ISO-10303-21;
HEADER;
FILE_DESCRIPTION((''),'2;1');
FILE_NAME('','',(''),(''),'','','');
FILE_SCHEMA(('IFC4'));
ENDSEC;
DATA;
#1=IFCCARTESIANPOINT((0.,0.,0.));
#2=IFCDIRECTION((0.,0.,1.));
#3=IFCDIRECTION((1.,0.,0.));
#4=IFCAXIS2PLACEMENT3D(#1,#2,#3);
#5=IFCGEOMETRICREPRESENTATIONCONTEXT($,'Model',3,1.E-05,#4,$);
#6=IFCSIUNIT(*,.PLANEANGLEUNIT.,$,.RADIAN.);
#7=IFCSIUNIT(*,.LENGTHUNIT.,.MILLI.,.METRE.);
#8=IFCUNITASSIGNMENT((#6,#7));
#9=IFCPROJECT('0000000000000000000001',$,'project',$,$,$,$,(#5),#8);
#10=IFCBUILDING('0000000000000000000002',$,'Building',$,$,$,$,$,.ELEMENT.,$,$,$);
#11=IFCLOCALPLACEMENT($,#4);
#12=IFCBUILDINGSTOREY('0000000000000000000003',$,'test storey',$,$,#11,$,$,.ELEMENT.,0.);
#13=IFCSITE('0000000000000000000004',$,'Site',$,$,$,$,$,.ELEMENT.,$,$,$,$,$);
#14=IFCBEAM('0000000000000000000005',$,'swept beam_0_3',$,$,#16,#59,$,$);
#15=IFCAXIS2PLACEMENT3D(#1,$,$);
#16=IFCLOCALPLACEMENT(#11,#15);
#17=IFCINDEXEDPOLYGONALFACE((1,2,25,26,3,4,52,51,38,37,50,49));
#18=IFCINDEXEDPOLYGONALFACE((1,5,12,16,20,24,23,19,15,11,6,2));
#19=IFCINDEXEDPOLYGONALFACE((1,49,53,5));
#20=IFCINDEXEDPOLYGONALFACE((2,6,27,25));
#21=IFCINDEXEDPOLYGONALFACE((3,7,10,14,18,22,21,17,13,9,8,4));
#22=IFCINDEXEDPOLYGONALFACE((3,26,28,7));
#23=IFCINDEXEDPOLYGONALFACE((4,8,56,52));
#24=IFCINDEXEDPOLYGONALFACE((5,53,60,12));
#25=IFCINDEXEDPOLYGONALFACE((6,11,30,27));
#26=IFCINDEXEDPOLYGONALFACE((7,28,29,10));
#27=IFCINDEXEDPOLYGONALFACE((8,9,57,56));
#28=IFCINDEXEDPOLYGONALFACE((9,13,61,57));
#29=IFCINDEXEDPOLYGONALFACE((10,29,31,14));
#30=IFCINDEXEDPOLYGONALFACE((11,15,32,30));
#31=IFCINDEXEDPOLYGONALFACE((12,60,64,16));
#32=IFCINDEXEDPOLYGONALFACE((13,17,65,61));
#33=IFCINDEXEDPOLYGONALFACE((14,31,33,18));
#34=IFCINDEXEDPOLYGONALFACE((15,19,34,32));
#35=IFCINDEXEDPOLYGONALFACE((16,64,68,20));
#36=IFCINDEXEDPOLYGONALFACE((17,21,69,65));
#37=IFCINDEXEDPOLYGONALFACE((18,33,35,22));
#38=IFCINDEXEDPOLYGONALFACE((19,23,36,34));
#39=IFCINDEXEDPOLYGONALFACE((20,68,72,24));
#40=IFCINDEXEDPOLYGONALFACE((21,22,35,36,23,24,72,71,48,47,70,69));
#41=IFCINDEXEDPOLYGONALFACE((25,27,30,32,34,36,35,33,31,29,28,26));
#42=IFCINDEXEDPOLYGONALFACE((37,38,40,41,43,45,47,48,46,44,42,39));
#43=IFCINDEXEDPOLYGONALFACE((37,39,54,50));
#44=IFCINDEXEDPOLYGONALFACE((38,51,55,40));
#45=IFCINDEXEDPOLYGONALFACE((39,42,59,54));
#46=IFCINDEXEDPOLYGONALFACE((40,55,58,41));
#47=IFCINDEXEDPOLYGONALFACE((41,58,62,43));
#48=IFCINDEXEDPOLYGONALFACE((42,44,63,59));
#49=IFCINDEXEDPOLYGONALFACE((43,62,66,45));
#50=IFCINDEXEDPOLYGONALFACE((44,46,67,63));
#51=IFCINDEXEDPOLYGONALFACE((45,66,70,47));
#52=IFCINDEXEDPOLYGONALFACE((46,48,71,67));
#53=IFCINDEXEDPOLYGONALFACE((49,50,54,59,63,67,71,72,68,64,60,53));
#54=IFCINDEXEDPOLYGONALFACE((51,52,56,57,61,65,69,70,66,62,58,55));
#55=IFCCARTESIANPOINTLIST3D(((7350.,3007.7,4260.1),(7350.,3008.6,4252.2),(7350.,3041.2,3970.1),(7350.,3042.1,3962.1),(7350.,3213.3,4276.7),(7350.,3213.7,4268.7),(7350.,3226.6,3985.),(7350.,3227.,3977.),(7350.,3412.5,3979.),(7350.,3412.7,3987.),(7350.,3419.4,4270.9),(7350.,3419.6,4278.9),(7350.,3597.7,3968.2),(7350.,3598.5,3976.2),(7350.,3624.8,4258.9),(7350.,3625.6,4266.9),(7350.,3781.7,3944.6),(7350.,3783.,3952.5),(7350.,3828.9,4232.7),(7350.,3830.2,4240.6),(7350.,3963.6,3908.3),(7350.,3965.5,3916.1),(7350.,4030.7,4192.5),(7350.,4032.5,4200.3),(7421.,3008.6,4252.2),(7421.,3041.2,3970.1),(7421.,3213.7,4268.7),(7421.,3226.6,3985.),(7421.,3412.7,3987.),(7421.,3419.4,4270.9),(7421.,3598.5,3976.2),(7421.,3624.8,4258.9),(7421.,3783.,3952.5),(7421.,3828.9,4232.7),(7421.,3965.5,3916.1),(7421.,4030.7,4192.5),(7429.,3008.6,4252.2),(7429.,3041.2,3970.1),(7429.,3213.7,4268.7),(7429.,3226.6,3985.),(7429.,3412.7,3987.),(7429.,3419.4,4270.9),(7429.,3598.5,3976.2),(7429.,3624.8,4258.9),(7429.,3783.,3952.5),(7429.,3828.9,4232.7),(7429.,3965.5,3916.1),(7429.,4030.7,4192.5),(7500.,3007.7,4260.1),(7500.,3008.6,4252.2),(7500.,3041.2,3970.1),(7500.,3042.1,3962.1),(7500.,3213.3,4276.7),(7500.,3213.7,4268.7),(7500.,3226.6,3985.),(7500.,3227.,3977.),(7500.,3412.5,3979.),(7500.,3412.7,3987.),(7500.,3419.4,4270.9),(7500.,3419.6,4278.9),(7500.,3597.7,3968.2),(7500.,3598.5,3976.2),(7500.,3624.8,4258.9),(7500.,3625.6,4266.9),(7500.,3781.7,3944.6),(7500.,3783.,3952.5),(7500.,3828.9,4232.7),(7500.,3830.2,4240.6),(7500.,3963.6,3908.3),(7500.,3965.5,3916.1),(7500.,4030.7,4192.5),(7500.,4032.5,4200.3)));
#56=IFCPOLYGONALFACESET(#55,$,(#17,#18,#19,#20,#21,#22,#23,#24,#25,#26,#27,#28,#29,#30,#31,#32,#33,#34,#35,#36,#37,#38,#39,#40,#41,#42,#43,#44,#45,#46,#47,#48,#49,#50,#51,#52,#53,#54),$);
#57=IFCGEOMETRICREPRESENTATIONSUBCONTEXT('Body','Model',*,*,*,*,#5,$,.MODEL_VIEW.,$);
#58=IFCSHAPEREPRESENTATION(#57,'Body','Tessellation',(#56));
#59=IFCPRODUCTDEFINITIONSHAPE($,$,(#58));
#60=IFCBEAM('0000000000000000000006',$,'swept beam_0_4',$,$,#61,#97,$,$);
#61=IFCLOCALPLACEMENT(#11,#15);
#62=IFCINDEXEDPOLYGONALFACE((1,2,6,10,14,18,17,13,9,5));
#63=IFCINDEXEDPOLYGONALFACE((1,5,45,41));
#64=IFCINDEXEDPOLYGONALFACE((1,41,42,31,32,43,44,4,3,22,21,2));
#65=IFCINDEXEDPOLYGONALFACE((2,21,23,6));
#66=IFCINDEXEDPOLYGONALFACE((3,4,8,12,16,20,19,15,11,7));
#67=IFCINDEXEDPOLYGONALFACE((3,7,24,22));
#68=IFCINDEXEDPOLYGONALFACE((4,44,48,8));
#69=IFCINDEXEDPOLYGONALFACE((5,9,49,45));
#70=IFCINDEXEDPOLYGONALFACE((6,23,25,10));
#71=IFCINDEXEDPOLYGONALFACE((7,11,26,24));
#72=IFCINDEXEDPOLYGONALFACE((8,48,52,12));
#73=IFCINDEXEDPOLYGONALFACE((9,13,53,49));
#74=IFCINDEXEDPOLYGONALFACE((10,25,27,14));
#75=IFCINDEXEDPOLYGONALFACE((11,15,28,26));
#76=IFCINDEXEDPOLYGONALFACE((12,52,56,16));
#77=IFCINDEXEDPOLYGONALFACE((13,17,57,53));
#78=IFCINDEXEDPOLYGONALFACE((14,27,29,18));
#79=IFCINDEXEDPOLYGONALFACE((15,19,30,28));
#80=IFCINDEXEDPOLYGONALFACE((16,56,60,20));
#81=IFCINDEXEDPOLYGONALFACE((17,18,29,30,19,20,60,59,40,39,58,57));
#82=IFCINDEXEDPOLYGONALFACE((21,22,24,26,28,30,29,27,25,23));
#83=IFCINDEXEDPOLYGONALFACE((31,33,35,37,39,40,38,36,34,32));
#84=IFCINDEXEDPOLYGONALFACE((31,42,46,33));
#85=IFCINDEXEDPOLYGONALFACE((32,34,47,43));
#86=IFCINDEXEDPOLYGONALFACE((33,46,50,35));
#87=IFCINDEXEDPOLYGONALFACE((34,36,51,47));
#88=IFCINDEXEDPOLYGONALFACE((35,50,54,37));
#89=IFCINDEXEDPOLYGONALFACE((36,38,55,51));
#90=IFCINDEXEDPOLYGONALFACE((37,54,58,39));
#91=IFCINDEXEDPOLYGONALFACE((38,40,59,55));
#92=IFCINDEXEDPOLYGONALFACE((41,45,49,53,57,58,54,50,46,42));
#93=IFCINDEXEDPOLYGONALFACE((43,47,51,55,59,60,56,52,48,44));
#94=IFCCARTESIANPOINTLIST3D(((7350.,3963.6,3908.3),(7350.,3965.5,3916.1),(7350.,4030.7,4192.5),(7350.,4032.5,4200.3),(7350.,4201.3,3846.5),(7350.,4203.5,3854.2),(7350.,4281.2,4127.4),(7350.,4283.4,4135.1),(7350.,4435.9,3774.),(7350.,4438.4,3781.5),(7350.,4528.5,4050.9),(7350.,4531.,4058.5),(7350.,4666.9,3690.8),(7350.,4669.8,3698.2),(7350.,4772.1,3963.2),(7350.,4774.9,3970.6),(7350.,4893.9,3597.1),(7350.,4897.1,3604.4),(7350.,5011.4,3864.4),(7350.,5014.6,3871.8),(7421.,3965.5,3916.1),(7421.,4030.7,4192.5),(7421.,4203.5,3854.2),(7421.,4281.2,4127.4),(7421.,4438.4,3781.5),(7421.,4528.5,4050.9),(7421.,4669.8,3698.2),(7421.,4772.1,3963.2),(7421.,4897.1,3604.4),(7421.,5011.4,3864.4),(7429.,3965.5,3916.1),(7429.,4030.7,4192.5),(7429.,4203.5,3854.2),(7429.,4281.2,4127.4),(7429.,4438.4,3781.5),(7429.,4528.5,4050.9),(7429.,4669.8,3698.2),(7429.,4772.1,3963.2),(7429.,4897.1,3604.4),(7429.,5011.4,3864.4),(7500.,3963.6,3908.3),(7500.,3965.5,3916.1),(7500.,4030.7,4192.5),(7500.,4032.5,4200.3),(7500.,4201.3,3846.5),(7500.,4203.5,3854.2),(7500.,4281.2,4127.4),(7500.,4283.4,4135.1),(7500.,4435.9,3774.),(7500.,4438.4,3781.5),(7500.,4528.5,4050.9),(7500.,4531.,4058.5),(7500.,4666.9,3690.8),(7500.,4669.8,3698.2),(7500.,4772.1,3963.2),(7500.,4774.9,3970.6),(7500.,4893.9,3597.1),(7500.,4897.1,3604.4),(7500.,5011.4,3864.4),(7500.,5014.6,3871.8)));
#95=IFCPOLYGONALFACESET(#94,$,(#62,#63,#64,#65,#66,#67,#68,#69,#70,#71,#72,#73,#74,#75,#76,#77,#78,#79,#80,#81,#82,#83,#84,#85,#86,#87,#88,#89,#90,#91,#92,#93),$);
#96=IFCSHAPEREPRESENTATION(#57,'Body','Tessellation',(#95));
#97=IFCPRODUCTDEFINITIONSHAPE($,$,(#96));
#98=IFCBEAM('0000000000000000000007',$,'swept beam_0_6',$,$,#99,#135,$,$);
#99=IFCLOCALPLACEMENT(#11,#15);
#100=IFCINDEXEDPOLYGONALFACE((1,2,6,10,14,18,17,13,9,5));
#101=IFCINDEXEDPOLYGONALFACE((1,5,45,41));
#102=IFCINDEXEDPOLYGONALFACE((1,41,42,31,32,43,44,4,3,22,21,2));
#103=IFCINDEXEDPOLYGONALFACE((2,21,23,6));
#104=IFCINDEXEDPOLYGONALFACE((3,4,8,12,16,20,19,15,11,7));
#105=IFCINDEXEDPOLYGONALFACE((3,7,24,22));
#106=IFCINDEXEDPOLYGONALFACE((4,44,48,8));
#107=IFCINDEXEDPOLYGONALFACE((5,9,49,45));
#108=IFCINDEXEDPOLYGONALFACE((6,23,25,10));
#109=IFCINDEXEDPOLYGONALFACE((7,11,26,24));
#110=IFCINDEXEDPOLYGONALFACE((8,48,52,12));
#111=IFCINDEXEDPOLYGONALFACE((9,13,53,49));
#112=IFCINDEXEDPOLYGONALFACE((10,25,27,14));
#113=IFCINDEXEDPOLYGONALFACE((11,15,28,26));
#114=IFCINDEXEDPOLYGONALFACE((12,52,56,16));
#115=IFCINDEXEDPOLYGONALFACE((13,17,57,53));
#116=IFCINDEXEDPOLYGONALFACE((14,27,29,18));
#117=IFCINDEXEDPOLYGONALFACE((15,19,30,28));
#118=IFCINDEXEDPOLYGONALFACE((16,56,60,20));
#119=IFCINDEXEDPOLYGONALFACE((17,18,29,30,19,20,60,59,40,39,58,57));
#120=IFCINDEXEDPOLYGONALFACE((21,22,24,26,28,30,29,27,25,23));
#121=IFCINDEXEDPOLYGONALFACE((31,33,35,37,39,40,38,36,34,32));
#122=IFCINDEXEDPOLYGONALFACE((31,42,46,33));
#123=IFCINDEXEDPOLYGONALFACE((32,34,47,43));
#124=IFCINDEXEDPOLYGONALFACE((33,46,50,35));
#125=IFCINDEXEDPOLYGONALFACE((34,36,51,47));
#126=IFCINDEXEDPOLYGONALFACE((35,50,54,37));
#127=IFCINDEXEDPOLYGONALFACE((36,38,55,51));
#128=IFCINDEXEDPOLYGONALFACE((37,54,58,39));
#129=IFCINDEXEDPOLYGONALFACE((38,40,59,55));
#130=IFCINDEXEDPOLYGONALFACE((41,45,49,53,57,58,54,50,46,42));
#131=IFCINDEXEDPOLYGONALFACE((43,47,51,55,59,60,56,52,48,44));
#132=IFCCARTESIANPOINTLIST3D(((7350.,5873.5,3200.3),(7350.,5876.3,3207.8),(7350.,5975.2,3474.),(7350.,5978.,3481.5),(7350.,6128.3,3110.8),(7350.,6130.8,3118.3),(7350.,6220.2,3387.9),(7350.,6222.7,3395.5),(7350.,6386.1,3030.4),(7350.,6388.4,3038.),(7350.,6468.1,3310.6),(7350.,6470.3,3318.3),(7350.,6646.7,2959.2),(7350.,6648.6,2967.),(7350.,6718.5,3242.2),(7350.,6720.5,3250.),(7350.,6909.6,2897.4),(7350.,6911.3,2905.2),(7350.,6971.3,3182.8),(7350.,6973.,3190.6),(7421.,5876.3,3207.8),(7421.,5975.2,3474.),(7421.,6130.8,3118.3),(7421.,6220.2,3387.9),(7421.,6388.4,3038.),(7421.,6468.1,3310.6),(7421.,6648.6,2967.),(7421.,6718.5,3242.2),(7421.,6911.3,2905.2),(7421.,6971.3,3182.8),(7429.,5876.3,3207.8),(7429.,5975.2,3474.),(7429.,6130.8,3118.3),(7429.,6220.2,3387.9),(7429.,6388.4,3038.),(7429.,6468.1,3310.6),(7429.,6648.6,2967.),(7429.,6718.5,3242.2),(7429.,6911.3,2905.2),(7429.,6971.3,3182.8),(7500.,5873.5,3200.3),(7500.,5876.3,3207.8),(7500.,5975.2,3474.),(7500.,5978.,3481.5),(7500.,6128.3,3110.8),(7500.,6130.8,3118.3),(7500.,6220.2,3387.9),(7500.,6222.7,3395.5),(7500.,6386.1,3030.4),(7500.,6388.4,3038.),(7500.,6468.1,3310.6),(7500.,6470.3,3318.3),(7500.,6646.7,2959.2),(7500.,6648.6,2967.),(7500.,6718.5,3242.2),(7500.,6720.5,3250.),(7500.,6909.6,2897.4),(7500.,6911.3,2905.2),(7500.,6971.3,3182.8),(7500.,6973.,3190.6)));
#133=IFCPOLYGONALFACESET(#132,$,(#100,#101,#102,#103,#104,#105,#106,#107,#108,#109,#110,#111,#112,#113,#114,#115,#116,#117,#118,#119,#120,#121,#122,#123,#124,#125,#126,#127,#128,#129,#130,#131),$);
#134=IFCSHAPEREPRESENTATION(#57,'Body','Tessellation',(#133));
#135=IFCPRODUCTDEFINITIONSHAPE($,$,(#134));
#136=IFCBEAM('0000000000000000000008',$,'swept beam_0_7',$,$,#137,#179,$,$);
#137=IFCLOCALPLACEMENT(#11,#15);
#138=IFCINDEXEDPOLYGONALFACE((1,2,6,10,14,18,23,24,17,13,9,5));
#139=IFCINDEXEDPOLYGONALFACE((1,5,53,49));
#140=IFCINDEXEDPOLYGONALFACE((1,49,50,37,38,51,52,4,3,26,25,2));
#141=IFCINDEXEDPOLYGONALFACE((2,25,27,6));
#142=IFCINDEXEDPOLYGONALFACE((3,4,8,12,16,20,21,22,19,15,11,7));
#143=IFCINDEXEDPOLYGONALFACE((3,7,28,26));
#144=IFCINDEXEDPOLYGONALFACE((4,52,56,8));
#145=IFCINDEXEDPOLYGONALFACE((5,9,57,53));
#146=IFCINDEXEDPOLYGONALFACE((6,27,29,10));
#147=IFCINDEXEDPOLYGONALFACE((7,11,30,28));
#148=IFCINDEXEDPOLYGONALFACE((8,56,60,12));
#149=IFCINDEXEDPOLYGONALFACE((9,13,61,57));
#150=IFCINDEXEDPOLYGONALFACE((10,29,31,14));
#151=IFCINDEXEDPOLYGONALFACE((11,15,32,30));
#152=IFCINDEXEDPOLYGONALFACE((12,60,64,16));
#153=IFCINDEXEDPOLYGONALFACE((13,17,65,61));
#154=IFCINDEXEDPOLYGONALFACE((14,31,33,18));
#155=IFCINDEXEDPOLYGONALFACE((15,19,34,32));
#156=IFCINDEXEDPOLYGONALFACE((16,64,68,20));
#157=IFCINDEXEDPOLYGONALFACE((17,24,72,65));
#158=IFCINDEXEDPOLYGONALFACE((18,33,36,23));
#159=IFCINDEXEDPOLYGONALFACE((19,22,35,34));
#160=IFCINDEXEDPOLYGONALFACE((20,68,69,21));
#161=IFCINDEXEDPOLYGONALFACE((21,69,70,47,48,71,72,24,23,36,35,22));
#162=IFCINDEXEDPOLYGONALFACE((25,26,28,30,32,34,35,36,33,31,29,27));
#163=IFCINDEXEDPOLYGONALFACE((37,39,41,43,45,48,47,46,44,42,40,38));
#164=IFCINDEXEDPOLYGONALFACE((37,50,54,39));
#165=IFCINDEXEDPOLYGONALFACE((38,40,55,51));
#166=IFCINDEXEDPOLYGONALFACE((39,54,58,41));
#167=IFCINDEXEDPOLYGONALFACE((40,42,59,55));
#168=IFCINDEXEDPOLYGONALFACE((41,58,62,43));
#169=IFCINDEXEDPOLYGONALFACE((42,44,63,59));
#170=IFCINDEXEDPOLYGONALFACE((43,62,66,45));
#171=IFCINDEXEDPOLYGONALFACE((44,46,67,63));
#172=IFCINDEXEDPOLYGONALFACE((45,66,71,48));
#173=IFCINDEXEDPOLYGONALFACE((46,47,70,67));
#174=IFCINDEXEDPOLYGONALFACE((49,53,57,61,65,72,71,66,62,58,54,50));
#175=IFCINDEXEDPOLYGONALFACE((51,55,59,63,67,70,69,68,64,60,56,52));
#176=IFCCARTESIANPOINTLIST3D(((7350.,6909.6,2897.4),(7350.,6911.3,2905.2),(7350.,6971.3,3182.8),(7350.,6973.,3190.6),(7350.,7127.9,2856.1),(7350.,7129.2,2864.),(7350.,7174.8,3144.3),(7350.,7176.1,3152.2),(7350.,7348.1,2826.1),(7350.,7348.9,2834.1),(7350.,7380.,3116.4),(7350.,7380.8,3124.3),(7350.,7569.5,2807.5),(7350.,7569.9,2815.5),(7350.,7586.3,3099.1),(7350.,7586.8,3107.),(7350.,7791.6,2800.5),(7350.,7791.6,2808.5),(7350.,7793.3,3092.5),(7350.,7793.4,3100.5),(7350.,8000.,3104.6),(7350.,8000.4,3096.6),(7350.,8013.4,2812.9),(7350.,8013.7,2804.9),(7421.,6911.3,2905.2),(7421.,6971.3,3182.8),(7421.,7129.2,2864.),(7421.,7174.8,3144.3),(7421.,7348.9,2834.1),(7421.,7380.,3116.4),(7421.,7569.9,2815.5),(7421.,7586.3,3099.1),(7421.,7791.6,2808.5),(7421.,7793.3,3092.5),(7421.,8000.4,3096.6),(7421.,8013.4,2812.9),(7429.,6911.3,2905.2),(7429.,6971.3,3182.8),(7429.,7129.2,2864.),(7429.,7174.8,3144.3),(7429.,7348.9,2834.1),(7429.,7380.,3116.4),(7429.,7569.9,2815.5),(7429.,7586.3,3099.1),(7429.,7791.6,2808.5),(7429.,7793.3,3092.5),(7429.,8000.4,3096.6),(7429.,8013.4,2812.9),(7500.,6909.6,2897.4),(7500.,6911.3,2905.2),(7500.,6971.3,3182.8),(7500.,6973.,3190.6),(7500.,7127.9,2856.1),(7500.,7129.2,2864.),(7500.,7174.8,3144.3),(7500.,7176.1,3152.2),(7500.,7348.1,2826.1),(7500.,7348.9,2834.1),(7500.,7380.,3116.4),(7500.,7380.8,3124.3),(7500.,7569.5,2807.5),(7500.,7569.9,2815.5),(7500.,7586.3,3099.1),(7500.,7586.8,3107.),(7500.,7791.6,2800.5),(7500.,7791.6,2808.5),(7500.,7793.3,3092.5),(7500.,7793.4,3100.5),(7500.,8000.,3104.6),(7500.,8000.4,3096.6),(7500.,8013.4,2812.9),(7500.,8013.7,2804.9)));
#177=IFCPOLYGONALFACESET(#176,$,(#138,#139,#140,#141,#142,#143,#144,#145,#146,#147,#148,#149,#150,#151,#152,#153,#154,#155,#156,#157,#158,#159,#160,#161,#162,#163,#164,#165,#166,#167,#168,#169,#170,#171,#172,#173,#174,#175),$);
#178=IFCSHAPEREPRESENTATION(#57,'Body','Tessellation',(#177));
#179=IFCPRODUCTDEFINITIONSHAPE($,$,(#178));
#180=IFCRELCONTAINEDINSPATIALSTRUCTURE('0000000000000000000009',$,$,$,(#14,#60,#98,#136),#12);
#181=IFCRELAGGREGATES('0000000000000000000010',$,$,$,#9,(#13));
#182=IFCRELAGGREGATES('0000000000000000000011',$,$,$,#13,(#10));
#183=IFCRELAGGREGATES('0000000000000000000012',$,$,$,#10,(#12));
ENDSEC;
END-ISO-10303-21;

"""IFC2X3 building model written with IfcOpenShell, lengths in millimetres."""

from ifc_helpers import new_model, entity, si_unit, origin_with_axes, place, context, subcontext, project, spatial, element, save


model = new_model("IFC2X3")

# Units and contexts
model_context = context("Model", 3, precision=1e-05, world=origin_with_axes())
body_context = subcontext(model_context, "Body", "Model", "MODEL_VIEW")
ifc_project = project(units=[si_unit("PLANEANGLEUNIT", "RADIAN"), si_unit("LENGTHUNIT", "METRE", prefix="MILLI")], contexts=[model_context])

# Site, building, storey
site = spatial("IfcSite", under=ifc_project, Name="Site", CompositionType="ELEMENT")
building = spatial("IfcBuilding", under=site, Name="Building", CompositionType="ELEMENT")
storey_placement = place(None, origin_with_axes())
storey = spatial("IfcBuildingStorey", under=building, at=storey_placement, Name="test storey", CompositionType="ELEMENT", Elevation=0.0)

# Beams
beam_1_placement = place(storey_placement, origin_with_axes())
element("IfcBeam", 1, at=beam_1_placement, inside=storey, Name="swept beam_0_3", context=body_context, shape_type="SweptSolid", body=[
    entity("IfcRevolvedAreaSolid", entity("IfcArbitraryClosedProfileDef", "AREA", None, entity("IfcPolyline", [entity("IfcCartesianPoint", [-292.0, 0.0]), entity("IfcCartesianPoint", [-292.0, 71.0]), entity("IfcCartesianPoint", [-8.0, 71.0]), entity("IfcCartesianPoint", [-8.0, 0.0]), entity("IfcCartesianPoint", [0.0, 0.0]), entity("IfcCartesianPoint", [0.0, 150.0]), entity("IfcCartesianPoint", [-8.0, 150.0]), entity("IfcCartesianPoint", [-8.0, 79.0]), entity("IfcCartesianPoint", [-292.0, 79.0]), entity("IfcCartesianPoint", [-292.0, 150.0]), entity("IfcCartesianPoint", [-300.0, 150.0]), entity("IfcCartesianPoint", [-300.0, 0.0]), entity("IfcCartesianPoint", [-292.0, 0.0])])), entity("IfcAxis2Placement3D", entity("IfcCartesianPoint", [7500.0, 3007.7, 4260.1]), entity("IfcDirection", [0.0, -0.9934, -0.1146]), entity("IfcDirection", [0.0, -0.1146, 0.9934])), entity("IfcAxis1Placement", entity("IfcCartesianPoint", [-2978.2, 0.0, 0.0]), entity("IfcDirection", [0.0, 1.0, 0.0])), 0.34641),
])
beam_2_placement = place(storey_placement, origin_with_axes())
element("IfcBeam", 2, at=beam_2_placement, inside=storey, Name="swept beam_0_4", context=body_context, shape_type="SweptSolid", body=[
    entity("IfcRevolvedAreaSolid", entity("IfcArbitraryClosedProfileDef", "AREA", None, entity("IfcPolyline", [entity("IfcCartesianPoint", [-292.0, 0.0]), entity("IfcCartesianPoint", [-292.0, 71.0]), entity("IfcCartesianPoint", [-8.0, 71.0]), entity("IfcCartesianPoint", [-8.0, 0.0]), entity("IfcCartesianPoint", [0.0, 0.0]), entity("IfcCartesianPoint", [0.0, 150.0]), entity("IfcCartesianPoint", [-8.0, 150.0]), entity("IfcCartesianPoint", [-8.0, 79.0]), entity("IfcCartesianPoint", [-292.0, 79.0]), entity("IfcCartesianPoint", [-292.0, 150.0]), entity("IfcCartesianPoint", [-300.0, 150.0]), entity("IfcCartesianPoint", [-300.0, 0.0]), entity("IfcCartesianPoint", [-292.0, 0.0])])), entity("IfcAxis2Placement3D", entity("IfcCartesianPoint", [7500.0, 4032.5, 4200.3]), entity("IfcDirection", [0.0, -0.9733, 0.2295]), entity("IfcDirection", [0.0, 0.2295, 0.9733])), entity("IfcAxis1Placement", entity("IfcCartesianPoint", [-5680.6, 0.0, 0.0]), entity("IfcDirection", [0.0, 1.0, 0.0])), 0.182555),
])
beam_3_placement = place(storey_placement, origin_with_axes())
element("IfcBeam", 3, at=beam_3_placement, inside=storey, Name="swept beam_0_6", context=body_context, shape_type="SweptSolid", body=[
    entity("IfcRevolvedAreaSolid", entity("IfcArbitraryClosedProfileDef", "AREA", None, entity("IfcPolyline", [entity("IfcCartesianPoint", [292.0, 0.0]), entity("IfcCartesianPoint", [292.0, -71.0]), entity("IfcCartesianPoint", [8.0, -71.0]), entity("IfcCartesianPoint", [8.0, 0.0]), entity("IfcCartesianPoint", [0.0, 0.0]), entity("IfcCartesianPoint", [0.0, -150.0]), entity("IfcCartesianPoint", [8.0, -150.0]), entity("IfcCartesianPoint", [8.0, -79.0]), entity("IfcCartesianPoint", [292.0, -79.0]), entity("IfcCartesianPoint", [292.0, -150.0]), entity("IfcCartesianPoint", [300.0, -150.0]), entity("IfcCartesianPoint", [300.0, 0.0]), entity("IfcCartesianPoint", [292.0, 0.0])])), entity("IfcAxis2Placement3D", entity("IfcCartesianPoint", [7500.0, 5978.0, 3481.5]), entity("IfcDirection", [0.0, -0.9374, 0.3483]), entity("IfcDirection", [0.0, -0.3483, -0.9374])), entity("IfcAxis1Placement", entity("IfcCartesianPoint", [-7271.1, 0.0, 0.0]), entity("IfcDirection", [0.0, 1.0, 0.0])), 0.142691),
])
beam_4_placement = place(storey_placement, origin_with_axes())
element("IfcBeam", 4, at=beam_4_placement, inside=storey, Name="swept beam_0_7", context=body_context, shape_type="SweptSolid", body=[
    entity("IfcRevolvedAreaSolid", entity("IfcArbitraryClosedProfileDef", "AREA", None, entity("IfcPolyline", [entity("IfcCartesianPoint", [292.0, 0.0]), entity("IfcCartesianPoint", [292.0, -71.0]), entity("IfcCartesianPoint", [8.0, -71.0]), entity("IfcCartesianPoint", [8.0, 0.0]), entity("IfcCartesianPoint", [0.0, 0.0]), entity("IfcCartesianPoint", [0.0, -150.0]), entity("IfcCartesianPoint", [8.0, -150.0]), entity("IfcCartesianPoint", [8.0, -79.0]), entity("IfcCartesianPoint", [292.0, -79.0]), entity("IfcCartesianPoint", [292.0, -150.0]), entity("IfcCartesianPoint", [300.0, -150.0]), entity("IfcCartesianPoint", [300.0, 0.0]), entity("IfcCartesianPoint", [292.0, 0.0])])), entity("IfcAxis2Placement3D", entity("IfcCartesianPoint", [7500.0, 6973.0, 3190.6]), entity("IfcDirection", [0.0, -0.9774, 0.2114]), entity("IfcDirection", [0.0, -0.2114, -0.9774])), entity("IfcAxis1Placement", entity("IfcCartesianPoint", [-3994.2, 0.0, 0.0]), entity("IfcDirection", [0.0, 1.0, 0.0])), 0.258747),
])

save(model, "model.ifc")
